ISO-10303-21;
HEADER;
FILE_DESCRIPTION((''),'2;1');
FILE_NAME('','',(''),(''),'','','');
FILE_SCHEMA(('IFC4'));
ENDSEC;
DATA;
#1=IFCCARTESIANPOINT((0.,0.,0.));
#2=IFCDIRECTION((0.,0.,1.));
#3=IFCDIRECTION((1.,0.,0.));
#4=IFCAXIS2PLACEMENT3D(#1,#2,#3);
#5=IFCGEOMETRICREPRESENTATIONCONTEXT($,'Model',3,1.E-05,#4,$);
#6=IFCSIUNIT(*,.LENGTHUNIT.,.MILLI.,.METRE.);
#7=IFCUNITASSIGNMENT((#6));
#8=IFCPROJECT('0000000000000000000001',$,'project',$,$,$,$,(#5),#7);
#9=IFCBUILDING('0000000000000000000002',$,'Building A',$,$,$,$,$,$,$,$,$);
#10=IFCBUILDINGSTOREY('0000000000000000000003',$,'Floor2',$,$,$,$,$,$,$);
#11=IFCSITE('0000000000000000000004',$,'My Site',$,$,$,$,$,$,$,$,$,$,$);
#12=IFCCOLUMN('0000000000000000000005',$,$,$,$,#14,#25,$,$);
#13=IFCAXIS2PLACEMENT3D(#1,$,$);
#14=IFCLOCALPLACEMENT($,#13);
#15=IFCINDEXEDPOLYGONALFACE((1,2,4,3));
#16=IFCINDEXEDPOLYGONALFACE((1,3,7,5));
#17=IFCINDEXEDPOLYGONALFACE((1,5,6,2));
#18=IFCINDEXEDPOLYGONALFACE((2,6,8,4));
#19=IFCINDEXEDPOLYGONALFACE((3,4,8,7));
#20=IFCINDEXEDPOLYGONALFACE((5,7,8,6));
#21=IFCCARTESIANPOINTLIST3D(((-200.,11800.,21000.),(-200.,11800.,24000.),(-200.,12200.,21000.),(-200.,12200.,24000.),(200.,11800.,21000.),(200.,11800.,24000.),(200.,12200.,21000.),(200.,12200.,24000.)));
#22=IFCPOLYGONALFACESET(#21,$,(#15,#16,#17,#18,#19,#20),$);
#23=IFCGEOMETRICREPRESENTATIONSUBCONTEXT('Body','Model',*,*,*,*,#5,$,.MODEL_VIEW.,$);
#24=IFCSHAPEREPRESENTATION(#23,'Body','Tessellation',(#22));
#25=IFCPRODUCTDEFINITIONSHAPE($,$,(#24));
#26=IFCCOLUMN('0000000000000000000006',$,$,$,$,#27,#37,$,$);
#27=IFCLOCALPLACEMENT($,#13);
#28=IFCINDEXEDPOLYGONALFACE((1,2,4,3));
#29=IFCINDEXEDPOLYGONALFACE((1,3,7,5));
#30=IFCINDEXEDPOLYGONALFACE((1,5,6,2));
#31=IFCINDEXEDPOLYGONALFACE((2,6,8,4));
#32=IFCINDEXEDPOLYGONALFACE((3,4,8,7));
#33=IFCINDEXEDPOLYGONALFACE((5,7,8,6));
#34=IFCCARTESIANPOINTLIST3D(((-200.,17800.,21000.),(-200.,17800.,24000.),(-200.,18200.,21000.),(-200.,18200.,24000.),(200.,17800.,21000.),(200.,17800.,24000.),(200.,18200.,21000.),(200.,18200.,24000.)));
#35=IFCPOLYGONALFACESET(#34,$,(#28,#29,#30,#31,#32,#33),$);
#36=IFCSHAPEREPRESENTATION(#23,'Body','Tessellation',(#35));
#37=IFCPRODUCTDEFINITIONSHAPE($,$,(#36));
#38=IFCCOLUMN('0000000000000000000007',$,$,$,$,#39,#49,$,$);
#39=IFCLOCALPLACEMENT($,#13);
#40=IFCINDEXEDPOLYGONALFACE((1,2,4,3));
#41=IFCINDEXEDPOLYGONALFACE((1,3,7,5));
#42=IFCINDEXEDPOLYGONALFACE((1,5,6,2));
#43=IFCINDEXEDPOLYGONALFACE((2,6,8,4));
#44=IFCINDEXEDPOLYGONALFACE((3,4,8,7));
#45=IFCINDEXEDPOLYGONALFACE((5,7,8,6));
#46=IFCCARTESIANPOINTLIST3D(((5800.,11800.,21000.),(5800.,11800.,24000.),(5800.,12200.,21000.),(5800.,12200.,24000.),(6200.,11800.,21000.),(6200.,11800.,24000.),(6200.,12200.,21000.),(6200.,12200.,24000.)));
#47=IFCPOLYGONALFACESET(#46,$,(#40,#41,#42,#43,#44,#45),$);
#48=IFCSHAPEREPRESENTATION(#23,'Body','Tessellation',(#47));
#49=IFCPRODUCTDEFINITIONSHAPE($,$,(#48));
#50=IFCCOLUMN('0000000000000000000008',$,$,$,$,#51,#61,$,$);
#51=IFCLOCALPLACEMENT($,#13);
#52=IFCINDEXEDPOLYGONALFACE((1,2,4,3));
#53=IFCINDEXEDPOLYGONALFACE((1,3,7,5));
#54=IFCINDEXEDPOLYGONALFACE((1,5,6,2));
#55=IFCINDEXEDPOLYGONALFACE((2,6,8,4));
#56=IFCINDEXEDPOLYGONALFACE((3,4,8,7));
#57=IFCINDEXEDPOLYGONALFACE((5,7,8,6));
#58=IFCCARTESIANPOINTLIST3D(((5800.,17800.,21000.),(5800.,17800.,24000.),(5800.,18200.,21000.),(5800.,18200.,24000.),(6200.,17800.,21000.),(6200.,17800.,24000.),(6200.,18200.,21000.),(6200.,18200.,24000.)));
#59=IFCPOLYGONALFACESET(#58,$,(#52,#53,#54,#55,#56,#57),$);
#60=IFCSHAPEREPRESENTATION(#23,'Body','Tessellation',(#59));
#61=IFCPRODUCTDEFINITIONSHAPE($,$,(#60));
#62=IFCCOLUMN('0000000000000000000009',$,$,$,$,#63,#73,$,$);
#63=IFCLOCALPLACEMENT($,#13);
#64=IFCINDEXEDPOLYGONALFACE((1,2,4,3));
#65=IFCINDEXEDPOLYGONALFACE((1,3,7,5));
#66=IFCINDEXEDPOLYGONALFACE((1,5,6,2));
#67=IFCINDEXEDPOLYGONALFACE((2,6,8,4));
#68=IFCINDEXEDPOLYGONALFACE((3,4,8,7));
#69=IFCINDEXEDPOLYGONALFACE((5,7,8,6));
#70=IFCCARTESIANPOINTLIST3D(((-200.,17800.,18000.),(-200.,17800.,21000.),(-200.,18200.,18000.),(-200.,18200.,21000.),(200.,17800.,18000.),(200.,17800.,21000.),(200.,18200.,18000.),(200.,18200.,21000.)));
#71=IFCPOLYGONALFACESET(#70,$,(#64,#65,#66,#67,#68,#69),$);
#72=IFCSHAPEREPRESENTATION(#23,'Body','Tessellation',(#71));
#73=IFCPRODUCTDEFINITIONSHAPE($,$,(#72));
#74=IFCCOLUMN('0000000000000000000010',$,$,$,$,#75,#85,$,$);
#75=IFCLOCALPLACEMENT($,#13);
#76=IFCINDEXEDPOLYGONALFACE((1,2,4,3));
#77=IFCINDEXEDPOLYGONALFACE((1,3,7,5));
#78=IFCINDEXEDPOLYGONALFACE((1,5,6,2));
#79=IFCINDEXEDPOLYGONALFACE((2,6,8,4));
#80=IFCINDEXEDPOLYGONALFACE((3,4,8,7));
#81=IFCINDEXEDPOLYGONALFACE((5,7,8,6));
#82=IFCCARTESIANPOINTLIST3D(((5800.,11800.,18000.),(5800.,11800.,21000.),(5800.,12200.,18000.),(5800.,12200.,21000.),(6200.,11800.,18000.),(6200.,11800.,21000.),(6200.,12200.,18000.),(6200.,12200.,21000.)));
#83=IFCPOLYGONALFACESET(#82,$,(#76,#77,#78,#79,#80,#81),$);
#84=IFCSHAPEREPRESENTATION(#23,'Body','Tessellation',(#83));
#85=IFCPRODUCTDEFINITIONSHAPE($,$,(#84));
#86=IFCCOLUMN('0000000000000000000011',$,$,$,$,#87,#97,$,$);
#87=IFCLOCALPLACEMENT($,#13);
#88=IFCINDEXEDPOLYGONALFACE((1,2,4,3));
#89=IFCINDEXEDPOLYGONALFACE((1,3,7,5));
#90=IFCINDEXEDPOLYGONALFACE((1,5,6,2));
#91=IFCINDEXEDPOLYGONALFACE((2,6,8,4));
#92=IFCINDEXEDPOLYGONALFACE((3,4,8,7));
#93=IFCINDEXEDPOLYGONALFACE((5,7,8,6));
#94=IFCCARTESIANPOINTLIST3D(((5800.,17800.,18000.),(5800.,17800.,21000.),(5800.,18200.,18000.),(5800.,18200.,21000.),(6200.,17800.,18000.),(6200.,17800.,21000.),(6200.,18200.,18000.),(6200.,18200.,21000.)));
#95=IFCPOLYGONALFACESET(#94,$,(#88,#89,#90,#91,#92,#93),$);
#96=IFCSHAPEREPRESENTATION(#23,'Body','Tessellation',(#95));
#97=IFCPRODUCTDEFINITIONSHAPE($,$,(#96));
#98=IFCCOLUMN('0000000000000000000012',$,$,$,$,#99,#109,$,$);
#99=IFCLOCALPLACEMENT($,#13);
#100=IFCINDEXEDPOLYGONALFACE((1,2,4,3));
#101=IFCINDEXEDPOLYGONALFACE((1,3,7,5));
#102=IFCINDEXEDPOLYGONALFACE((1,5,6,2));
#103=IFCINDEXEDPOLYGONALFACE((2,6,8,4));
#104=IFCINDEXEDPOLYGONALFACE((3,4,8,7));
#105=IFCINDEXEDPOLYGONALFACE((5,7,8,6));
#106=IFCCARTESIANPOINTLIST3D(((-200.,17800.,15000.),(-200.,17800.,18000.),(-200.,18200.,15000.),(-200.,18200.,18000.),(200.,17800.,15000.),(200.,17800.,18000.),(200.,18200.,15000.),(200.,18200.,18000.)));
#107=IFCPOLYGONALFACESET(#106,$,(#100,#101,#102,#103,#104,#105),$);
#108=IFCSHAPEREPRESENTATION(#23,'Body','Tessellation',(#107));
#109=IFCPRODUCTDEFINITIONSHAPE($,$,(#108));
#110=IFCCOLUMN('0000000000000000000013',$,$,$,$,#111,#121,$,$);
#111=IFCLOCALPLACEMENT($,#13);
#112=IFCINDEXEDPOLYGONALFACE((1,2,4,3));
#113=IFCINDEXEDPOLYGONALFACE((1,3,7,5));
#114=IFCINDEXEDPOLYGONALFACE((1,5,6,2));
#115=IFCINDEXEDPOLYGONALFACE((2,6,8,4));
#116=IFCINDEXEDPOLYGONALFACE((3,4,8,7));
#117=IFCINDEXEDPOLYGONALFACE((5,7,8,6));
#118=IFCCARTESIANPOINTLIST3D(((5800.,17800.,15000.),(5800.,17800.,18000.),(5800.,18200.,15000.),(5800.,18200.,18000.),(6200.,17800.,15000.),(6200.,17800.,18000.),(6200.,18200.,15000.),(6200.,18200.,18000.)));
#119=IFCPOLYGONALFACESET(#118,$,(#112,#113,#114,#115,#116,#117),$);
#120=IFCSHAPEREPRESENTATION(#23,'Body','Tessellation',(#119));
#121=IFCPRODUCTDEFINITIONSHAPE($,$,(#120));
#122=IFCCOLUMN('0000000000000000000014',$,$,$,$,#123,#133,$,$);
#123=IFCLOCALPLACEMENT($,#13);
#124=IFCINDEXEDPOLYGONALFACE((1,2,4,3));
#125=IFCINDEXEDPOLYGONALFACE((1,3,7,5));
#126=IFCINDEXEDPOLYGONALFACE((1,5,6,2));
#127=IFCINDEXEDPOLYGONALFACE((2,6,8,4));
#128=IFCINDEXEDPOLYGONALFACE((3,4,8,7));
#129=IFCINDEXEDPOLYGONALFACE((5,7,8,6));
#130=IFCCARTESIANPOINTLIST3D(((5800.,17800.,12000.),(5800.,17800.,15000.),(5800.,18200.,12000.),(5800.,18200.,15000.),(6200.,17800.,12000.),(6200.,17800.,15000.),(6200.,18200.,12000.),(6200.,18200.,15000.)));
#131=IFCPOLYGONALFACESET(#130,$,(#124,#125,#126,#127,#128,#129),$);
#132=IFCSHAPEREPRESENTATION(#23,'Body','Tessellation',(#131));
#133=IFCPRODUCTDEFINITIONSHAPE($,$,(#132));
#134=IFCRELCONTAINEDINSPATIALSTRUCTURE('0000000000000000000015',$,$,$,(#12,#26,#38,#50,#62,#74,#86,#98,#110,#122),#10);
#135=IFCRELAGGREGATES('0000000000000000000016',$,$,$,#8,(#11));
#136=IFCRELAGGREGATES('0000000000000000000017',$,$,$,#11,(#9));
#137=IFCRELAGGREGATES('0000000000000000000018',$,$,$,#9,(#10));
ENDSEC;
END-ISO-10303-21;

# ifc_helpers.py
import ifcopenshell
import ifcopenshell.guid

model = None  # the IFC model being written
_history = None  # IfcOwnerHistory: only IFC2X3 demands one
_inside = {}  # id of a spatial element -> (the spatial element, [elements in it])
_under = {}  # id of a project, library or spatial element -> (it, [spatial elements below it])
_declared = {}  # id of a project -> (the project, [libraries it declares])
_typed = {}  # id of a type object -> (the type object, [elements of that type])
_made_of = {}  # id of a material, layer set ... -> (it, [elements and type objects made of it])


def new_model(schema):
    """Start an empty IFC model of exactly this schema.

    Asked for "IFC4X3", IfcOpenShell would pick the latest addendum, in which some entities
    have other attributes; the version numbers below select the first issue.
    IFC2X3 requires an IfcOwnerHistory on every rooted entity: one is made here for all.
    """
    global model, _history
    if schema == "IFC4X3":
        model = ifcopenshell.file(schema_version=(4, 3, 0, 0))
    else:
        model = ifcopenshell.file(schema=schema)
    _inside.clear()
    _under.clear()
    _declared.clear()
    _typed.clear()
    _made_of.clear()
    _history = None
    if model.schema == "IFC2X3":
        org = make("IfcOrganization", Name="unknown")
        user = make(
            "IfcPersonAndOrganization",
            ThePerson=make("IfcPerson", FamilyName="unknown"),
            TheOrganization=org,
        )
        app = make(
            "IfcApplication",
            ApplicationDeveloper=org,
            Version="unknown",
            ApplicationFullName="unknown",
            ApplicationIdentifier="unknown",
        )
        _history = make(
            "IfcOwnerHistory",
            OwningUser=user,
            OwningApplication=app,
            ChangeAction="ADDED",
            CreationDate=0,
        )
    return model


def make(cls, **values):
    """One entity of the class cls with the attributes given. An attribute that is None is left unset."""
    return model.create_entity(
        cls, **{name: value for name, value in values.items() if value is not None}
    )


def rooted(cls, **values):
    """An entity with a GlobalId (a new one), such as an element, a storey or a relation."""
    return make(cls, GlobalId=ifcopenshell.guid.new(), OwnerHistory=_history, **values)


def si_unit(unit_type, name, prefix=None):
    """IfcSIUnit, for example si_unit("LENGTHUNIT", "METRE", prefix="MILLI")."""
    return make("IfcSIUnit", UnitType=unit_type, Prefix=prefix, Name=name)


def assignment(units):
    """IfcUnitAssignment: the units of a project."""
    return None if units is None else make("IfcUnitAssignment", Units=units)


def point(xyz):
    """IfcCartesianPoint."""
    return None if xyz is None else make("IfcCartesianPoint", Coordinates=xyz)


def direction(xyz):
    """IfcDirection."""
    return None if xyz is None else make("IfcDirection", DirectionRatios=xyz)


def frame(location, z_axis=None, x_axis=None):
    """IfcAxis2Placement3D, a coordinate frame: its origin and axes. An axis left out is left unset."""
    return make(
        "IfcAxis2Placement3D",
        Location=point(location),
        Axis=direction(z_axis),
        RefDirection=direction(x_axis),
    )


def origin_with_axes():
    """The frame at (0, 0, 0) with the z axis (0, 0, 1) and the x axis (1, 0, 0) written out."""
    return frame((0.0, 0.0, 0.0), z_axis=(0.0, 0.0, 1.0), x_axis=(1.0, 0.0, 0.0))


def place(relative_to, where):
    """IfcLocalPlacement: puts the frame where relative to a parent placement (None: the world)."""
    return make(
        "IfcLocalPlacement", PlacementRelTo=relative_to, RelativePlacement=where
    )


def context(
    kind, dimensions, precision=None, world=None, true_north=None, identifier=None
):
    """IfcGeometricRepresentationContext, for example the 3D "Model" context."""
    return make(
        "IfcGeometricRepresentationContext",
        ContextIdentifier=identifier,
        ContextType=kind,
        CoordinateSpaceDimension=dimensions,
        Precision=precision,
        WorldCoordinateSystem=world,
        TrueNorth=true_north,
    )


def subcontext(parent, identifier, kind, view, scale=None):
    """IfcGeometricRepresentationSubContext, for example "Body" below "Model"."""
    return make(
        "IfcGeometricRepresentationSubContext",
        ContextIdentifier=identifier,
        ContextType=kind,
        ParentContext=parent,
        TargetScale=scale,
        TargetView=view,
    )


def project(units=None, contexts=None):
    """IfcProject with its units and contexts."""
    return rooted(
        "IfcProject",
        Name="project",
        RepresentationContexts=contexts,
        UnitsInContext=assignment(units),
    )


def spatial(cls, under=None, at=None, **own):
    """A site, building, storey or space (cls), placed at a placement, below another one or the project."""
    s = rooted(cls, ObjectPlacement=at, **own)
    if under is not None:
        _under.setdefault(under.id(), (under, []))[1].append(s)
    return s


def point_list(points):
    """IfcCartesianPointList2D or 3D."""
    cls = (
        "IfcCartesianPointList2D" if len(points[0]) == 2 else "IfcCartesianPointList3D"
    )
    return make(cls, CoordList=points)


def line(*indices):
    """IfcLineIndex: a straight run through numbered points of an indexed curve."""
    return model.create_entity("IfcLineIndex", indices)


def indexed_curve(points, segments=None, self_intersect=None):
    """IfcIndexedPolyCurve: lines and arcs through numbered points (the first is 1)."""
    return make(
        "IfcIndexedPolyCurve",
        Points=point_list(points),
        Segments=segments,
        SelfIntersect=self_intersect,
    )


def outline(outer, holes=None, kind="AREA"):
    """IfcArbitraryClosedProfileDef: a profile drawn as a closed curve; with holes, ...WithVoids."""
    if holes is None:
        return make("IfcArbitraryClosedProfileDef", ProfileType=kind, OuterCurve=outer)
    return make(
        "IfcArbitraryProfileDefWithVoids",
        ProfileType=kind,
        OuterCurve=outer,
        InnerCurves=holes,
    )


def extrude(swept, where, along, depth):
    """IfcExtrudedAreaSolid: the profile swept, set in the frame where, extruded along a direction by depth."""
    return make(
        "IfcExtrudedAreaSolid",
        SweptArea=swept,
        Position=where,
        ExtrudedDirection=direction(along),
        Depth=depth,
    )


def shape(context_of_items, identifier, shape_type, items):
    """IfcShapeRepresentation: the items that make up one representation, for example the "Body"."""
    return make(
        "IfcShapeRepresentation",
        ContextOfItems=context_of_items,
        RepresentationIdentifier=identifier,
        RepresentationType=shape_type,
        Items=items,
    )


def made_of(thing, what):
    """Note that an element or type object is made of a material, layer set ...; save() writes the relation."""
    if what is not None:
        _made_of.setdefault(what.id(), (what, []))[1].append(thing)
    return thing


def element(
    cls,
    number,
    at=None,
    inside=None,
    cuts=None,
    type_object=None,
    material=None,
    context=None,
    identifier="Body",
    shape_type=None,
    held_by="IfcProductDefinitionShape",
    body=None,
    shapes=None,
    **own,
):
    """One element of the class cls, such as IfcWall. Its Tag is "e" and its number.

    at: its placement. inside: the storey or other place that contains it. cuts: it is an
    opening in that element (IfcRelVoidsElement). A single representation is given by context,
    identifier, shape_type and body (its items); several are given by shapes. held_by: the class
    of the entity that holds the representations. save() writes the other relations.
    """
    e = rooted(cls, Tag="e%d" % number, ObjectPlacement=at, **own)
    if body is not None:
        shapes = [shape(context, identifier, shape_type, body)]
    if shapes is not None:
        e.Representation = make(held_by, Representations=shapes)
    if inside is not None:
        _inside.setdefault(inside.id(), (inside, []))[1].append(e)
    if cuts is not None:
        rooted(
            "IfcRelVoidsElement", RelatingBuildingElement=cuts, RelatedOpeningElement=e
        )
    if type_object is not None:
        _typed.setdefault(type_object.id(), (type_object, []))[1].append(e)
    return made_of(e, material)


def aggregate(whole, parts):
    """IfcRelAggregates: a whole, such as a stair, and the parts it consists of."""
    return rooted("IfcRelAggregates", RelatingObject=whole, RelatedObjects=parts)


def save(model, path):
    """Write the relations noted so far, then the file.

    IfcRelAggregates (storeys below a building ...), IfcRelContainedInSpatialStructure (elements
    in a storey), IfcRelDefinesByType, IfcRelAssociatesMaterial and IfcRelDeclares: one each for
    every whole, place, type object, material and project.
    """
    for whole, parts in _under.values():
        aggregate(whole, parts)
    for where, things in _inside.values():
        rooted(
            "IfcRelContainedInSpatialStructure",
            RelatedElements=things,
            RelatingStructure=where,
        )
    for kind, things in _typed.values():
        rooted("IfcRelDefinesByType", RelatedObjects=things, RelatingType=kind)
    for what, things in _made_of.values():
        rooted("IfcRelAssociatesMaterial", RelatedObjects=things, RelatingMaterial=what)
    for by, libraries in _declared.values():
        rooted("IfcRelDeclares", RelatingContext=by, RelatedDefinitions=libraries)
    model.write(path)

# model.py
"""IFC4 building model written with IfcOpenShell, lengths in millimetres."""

from ifc_helpers import new_model, si_unit, frame, origin_with_axes, place, context, subcontext, project, spatial, line, indexed_curve, outline, extrude, element, save


model = new_model("IFC4")

# Units and contexts
model_context = context("Model", 3, precision=1e-05, world=origin_with_axes())
body_context = subcontext(model_context, "Body", "Model", "MODEL_VIEW")
ifc_project = project(units=[si_unit("LENGTHUNIT", "METRE", prefix="MILLI")], contexts=[model_context])

# Site, building, storey
site = spatial("IfcSite", under=ifc_project, Name="My Site")
building = spatial("IfcBuilding", under=site, Name="Building A")
storey = spatial("IfcBuildingStorey", under=building, Name="Floor2")

# Columns
for number, where, z_axis, x_axis in (
    (1, (0.0, 12000.0, 21000.0), (0.0, 0.0, 1.0), (1.0, 0.0, 0.0)),
    (2, (0.0, 18000.0, 21000.0), (0.0, 0.0, 1.0), (1.0, 0.0, 0.0)),
    (3, (6000.0, 12000.0, 21000.0), (0.0, 0.0, 1.0), (1.0, 0.0, 0.0)),
    (4, (6000.0, 18000.0, 21000.0), (0.0, 0.0, 1.0), (1.0, 0.0, 0.0)),
    (5, (0.0, 18000.0, 18000.0), (0.0, 0.0, 1.0), (1.0, 0.0, 0.0)),
    (6, (6000.0, 12000.0, 18000.0), (0.0, 0.0, 1.0), (1.0, 0.0, 0.0)),
    (7, (6000.0, 18000.0, 18000.0), (0.0, 0.0, 1.0), (1.0, 0.0, 0.0)),
    (8, (0.0, 18000.0, 15000.0), (0.0, 0.0, 1.0), (1.0, 0.0, 0.0)),
    (9, (6000.0, 18000.0, 15000.0), (0.0, 0.0, 1.0), (1.0, 0.0, 0.0)),
    (10, (6000.0, 18000.0, 12000.0), (0.0, 0.0, 1.0), (1.0, 0.0, 0.0)),
):
    element("IfcColumn", number, at=place(None, frame(where, z_axis=z_axis, x_axis=x_axis)), inside=storey, context=body_context, shape_type="SweptSolid", body=[
        extrude(outline(indexed_curve([(-200.0, -200.0), (200.0, -200.0), (200.0, 200.0), (-200.0, 200.0)], segments=[line(1, 2, 3, 4, 1)])), origin_with_axes(), (0.0, 0.0, 1.0), 3000.0),
    ])

save(model, "model.ifc")
